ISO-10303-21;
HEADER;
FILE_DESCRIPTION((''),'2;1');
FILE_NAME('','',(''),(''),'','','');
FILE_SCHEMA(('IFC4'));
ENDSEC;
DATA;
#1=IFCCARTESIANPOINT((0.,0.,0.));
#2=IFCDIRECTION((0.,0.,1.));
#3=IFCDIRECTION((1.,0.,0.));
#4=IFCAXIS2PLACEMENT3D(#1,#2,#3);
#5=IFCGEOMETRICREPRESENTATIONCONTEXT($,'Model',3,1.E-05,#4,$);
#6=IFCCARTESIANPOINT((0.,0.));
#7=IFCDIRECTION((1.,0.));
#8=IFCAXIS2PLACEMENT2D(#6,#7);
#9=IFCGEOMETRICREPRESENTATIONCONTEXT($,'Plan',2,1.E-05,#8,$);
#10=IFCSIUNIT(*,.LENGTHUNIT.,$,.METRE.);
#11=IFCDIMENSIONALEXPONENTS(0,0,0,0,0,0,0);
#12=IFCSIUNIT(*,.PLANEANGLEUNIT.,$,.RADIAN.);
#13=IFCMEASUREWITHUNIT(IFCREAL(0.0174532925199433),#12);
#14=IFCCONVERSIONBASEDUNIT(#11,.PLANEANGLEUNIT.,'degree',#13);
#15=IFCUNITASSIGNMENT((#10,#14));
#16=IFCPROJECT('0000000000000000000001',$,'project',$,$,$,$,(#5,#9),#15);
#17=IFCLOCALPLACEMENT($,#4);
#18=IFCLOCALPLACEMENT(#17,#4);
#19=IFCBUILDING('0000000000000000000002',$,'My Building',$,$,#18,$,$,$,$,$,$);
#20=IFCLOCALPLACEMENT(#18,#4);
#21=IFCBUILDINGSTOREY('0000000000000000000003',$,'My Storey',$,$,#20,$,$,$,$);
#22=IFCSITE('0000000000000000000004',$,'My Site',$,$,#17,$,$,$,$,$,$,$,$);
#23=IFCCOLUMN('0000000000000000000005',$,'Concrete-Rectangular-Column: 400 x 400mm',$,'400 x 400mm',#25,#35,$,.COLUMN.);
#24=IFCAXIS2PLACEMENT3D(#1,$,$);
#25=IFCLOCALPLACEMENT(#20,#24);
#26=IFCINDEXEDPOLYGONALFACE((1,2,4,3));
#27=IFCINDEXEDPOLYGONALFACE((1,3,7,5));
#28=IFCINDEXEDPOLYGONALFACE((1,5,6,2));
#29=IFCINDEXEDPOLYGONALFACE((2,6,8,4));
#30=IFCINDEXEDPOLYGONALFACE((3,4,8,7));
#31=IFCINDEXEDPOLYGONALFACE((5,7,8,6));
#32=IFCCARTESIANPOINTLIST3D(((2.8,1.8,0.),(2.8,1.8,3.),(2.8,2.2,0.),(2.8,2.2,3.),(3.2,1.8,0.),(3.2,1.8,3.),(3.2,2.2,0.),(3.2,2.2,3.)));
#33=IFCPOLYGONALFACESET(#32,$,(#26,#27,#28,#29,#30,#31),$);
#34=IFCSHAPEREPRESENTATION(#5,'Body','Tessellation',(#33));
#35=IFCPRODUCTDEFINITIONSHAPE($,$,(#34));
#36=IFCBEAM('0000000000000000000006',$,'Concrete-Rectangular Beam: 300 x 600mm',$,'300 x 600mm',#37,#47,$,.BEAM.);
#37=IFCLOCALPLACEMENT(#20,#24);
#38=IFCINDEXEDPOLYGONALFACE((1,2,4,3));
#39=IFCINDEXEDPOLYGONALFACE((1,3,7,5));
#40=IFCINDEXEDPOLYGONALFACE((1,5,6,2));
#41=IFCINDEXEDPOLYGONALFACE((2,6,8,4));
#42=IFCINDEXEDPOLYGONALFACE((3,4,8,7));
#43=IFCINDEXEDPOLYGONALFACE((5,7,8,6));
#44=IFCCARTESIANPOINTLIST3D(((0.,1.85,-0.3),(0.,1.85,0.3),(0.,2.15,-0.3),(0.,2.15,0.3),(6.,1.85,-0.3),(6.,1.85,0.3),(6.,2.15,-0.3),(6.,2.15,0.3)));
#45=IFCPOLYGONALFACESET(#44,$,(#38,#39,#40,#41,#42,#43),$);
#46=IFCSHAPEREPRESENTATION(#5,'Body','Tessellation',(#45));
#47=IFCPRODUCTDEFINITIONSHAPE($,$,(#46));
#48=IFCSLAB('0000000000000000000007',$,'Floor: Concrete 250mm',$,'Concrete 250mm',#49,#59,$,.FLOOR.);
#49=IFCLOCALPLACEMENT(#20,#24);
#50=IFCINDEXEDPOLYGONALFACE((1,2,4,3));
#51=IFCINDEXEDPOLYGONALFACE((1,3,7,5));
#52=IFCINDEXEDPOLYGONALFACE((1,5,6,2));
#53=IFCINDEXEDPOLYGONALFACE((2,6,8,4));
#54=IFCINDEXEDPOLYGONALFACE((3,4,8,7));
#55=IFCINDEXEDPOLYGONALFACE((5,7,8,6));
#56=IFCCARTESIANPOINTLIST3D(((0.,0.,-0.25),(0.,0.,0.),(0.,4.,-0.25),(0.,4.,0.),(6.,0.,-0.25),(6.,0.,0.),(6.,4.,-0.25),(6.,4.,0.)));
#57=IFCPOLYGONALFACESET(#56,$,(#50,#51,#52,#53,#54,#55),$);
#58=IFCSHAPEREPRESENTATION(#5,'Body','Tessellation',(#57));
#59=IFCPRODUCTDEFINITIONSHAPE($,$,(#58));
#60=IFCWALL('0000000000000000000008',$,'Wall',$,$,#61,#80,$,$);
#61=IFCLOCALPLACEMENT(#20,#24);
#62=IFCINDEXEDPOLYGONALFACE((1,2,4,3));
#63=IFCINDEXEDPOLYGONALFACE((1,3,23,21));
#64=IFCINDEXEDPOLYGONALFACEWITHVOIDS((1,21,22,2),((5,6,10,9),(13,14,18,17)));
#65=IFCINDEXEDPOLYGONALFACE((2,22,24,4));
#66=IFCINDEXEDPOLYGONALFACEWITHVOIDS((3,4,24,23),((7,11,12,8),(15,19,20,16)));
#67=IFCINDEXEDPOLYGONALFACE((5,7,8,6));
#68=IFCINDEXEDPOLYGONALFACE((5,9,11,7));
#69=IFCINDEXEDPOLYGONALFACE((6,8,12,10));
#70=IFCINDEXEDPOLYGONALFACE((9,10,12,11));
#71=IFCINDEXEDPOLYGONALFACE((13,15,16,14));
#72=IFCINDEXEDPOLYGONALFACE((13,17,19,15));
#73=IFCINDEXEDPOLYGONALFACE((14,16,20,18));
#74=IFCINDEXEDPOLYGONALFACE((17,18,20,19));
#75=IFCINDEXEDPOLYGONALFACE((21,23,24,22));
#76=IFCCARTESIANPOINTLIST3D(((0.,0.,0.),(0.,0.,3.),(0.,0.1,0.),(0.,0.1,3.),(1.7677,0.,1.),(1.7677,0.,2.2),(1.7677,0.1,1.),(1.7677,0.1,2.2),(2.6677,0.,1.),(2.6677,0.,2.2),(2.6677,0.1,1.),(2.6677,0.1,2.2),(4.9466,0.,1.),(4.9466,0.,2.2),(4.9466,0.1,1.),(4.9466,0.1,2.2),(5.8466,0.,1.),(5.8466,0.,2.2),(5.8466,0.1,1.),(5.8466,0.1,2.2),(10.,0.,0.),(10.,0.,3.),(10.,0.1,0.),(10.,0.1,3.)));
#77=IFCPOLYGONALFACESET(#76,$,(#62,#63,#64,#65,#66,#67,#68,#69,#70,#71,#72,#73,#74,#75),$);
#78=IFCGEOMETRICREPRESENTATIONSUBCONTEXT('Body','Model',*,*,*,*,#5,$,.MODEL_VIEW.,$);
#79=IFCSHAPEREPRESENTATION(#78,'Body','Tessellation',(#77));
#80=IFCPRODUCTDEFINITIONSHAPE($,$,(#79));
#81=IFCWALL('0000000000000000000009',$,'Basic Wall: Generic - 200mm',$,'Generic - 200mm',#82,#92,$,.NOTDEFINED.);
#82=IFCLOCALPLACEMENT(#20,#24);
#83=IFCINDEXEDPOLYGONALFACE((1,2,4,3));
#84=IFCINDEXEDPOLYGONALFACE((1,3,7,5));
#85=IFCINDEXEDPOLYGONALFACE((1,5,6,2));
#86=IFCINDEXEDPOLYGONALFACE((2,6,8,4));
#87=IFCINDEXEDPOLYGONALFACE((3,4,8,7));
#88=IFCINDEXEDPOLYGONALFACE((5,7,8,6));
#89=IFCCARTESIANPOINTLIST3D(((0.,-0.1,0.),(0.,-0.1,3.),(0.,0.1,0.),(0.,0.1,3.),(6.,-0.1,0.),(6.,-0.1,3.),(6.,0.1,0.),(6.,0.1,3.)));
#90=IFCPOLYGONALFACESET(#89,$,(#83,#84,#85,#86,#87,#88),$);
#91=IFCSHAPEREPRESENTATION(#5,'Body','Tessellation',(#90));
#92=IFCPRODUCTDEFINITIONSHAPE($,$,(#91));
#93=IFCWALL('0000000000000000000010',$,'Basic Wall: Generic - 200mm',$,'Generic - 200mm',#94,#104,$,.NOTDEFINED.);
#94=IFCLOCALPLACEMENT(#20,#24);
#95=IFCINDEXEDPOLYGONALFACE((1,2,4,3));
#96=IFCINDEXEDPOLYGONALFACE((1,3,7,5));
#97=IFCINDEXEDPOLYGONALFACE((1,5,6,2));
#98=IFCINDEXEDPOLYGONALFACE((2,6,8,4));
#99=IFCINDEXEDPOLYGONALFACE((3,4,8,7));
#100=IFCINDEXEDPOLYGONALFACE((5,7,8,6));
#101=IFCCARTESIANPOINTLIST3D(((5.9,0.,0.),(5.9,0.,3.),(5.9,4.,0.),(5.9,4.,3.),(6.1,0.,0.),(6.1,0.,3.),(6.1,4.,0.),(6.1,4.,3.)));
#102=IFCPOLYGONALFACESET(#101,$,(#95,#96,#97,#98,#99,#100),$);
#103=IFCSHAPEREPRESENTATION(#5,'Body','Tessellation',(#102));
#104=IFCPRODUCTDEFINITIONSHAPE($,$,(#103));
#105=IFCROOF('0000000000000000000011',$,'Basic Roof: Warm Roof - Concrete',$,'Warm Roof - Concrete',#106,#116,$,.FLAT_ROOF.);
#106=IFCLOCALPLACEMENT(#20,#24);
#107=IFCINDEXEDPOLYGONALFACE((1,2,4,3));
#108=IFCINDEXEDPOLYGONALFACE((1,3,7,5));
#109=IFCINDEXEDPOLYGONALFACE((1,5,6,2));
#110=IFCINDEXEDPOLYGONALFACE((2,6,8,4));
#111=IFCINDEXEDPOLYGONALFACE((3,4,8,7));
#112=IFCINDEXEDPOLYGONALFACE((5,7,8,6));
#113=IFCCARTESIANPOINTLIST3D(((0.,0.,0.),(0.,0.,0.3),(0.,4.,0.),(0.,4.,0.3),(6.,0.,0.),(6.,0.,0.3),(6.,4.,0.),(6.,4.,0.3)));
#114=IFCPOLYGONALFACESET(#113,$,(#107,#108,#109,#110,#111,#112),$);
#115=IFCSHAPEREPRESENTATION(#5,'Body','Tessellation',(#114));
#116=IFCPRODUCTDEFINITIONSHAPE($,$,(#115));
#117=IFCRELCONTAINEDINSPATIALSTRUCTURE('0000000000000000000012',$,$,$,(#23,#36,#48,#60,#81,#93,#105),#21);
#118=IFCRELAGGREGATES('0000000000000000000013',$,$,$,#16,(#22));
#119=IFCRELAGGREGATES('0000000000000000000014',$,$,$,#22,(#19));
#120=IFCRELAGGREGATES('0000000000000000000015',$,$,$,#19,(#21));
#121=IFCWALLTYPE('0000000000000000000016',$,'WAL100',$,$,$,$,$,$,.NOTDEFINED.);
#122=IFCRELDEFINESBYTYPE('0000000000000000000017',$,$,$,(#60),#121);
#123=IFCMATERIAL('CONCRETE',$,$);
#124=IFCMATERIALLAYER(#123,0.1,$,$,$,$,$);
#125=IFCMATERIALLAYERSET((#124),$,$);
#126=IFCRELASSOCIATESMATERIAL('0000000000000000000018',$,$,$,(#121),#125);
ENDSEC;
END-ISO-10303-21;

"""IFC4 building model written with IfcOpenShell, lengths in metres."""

from ifc_helpers import new_model, entity, si_unit, converted_unit, frame, frame_2d, origin, origin_with_axes, origin_2d, origin_2d_with_axis, place, context, subcontext, project, spatial, polyline, line, indexed_curve, rectangle, outline, extrude, source, transform, mapped, material, layer, layer_set, type_object, element, save


model = new_model("IFC4")

# Units and contexts
model_context = context("Model", 3, precision=1e-05, world=origin_with_axes())
plan_context = context("Plan", 2, precision=1e-05, world=origin_2d_with_axis())
body_context = subcontext(model_context, "Body", "Model", "MODEL_VIEW")
ifc_project = project(units=[si_unit("LENGTHUNIT", "METRE"), converted_unit("PLANEANGLEUNIT", "degree", entity("IfcReal", 0.0174532925199433), si_unit("PLANEANGLEUNIT", "RADIAN"), dimensions=[0, 0, 0, 0, 0, 0, 0])], contexts=[model_context, plan_context])

# Site, building, storey
site_placement = place(None, origin_with_axes())
site = spatial("IfcSite", under=ifc_project, at=site_placement, Name="My Site")
building_placement = place(site_placement, origin_with_axes())
building = spatial("IfcBuilding", under=site, at=building_placement, Name="My Building")
storey_placement = place(building_placement, origin_with_axes())
storey = spatial("IfcBuildingStorey", under=building, at=storey_placement, Name="My Storey")

# Column
column_placement = place(storey_placement, frame((3.0, 2.0, 0.0), z_axis=(0.0, 0.0, 1.0), x_axis=(1.0, 0.0, 0.0)))
element("IfcColumn", 1, at=column_placement, inside=storey, Name="Concrete-Rectangular-Column: 400 x 400mm", ObjectType="400 x 400mm", PredefinedType="COLUMN", context=model_context, shape_type="SweptSolid", body=[
    extrude(rectangle(XDim=0.4, YDim=0.4, at=origin_2d()), origin(), (0.0, 0.0, 1.0), 3.0),
])

# Beam
beam_placement = place(storey_placement, frame((0.0, 2.0, 0.0), z_axis=(1.0, 0.0, 0.0), x_axis=(0.0, 1.0, 0.0)))
element("IfcBeam", 2, at=beam_placement, inside=storey, Name="Concrete-Rectangular Beam: 300 x 600mm", ObjectType="300 x 600mm", PredefinedType="BEAM", context=model_context, shape_type="SweptSolid", body=[
    extrude(rectangle(XDim=0.3, YDim=0.6, at=origin_2d()), origin(), (0.0, 0.0, 1.0), 6.0),
])

# Slab
slab_placement = place(storey_placement, frame((0.0, 0.0, -0.25)))
element("IfcSlab", 3, at=slab_placement, inside=storey, Name="Floor: Concrete 250mm", ObjectType="Concrete 250mm", PredefinedType="FLOOR", context=model_context, shape_type="SweptSolid", body=[
    extrude(outline(polyline([(0.0, 0.0), (6.0, 0.0), (6.0, 4.0), (0.0, 4.0), (0.0, 0.0)])), origin(), (0.0, 0.0, 1.0), 0.25),
])

# Wall, openings
ifc_material = material(Name="CONCRETE")
ifc_layer = layer(ifc_material, 0.1)
ifc_layer_set = layer_set([ifc_layer])
wall_type = type_object("IfcWallType", Name="WAL100", PredefinedType="NOTDEFINED", material=ifc_layer_set)
wall_1_placement = place(storey_placement, origin_with_axes())
wall_1 = element("IfcWall", 4, at=wall_1_placement, inside=storey, type_object=wall_type, Name="Wall", context=body_context, shape_type="SweptSolid", body=[
    extrude(outline(indexed_curve([(0.0, 0.0), (0.0, 0.1), (10.0, 0.1), (10.0, 0.0), (0.0, 0.0)], self_intersect=False)), origin_with_axes(), (0.0, 0.0, 1.0), 3.0),
])
shared_shape = source(origin_with_axes(), body_context, "Body", "SweptSolid", [
    extrude(outline(indexed_curve([(0.0, 0.0), (0.9, 0.0), (0.9, 1.2), (0.0, 1.2)], segments=[line(1, 2, 3, 4, 1)])), frame((0.0, -0.6, 0.0), z_axis=(0.0, -1.0, 0.0), x_axis=(1.0, 0.0, 0.0)), (0.0, 0.0, -1.0), 1.2),
])
opening_1_placement = place(wall_1_placement, frame((1.7677, 0.0, 1.0), z_axis=(0.0, 0.0, 1.0), x_axis=(1.0, 0.0, 0.0)))
element("IfcOpeningElement", 5, at=opening_1_placement, cuts=wall_1, PredefinedType="OPENING", context=body_context, shape_type="MappedRepresentation", body=[
    mapped(shared_shape, transform((0.0, 0.0, 0.0), x_axis=(1.0, 0.0, 0.0), y_axis=(0.0, 1.0, 0.0), z_axis=(0.0, 0.0, 1.0), scale=1.0)),
])
opening_2_placement = place(wall_1_placement, frame((4.9466, 0.0, 1.0), z_axis=(0.0, 0.0, 1.0), x_axis=(1.0, 0.0, 0.0)))
element("IfcOpeningElement", 6, at=opening_2_placement, cuts=wall_1, PredefinedType="OPENING", context=body_context, shape_type="MappedRepresentation", body=[
    mapped(shared_shape, transform((0.0, 0.0, 0.0), x_axis=(1.0, 0.0, 0.0), y_axis=(0.0, 1.0, 0.0), z_axis=(0.0, 0.0, 1.0), scale=1.0)),
])

# Walls
wall_2_placement = place(storey_placement, origin_with_axes())
element("IfcWall", 7, at=wall_2_placement, inside=storey, Name="Basic Wall: Generic - 200mm", ObjectType="Generic - 200mm", PredefinedType="NOTDEFINED", context=model_context, shape_type="SweptSolid", body=[
    extrude(rectangle(XDim=6.0, YDim=0.2, at=frame_2d((3.0, 0.0))), origin(), (0.0, 0.0, 1.0), 3.0),
])
wall_3_placement = place(storey_placement, frame((6.0, 0.0, 0.0), z_axis=(0.0, 0.0, 1.0), x_axis=(0.0, 1.0, 0.0)))
element("IfcWall", 8, at=wall_3_placement, inside=storey, Name="Basic Wall: Generic - 200mm", ObjectType="Generic - 200mm", PredefinedType="NOTDEFINED", context=model_context, shape_type="SweptSolid", body=[
    extrude(rectangle(XDim=4.0, YDim=0.2, at=frame_2d((2.0, 0.0))), origin(), (0.0, 0.0, 1.0), 3.0),
])

# Roof
roof_placement = place(storey_placement, origin())
element("IfcRoof", 9, at=roof_placement, inside=storey, Name="Basic Roof: Warm Roof - Concrete", ObjectType="Warm Roof - Concrete", PredefinedType="FLAT_ROOF", context=model_context, shape_type="SweptSolid", body=[
    extrude(outline(polyline([(0.0, 0.0), (6.0, 0.0), (6.0, 4.0), (0.0, 4.0), (0.0, 0.0)])), origin(), (0.0, 0.0, 1.0), 0.3),
])

save(model, "model.ifc")
